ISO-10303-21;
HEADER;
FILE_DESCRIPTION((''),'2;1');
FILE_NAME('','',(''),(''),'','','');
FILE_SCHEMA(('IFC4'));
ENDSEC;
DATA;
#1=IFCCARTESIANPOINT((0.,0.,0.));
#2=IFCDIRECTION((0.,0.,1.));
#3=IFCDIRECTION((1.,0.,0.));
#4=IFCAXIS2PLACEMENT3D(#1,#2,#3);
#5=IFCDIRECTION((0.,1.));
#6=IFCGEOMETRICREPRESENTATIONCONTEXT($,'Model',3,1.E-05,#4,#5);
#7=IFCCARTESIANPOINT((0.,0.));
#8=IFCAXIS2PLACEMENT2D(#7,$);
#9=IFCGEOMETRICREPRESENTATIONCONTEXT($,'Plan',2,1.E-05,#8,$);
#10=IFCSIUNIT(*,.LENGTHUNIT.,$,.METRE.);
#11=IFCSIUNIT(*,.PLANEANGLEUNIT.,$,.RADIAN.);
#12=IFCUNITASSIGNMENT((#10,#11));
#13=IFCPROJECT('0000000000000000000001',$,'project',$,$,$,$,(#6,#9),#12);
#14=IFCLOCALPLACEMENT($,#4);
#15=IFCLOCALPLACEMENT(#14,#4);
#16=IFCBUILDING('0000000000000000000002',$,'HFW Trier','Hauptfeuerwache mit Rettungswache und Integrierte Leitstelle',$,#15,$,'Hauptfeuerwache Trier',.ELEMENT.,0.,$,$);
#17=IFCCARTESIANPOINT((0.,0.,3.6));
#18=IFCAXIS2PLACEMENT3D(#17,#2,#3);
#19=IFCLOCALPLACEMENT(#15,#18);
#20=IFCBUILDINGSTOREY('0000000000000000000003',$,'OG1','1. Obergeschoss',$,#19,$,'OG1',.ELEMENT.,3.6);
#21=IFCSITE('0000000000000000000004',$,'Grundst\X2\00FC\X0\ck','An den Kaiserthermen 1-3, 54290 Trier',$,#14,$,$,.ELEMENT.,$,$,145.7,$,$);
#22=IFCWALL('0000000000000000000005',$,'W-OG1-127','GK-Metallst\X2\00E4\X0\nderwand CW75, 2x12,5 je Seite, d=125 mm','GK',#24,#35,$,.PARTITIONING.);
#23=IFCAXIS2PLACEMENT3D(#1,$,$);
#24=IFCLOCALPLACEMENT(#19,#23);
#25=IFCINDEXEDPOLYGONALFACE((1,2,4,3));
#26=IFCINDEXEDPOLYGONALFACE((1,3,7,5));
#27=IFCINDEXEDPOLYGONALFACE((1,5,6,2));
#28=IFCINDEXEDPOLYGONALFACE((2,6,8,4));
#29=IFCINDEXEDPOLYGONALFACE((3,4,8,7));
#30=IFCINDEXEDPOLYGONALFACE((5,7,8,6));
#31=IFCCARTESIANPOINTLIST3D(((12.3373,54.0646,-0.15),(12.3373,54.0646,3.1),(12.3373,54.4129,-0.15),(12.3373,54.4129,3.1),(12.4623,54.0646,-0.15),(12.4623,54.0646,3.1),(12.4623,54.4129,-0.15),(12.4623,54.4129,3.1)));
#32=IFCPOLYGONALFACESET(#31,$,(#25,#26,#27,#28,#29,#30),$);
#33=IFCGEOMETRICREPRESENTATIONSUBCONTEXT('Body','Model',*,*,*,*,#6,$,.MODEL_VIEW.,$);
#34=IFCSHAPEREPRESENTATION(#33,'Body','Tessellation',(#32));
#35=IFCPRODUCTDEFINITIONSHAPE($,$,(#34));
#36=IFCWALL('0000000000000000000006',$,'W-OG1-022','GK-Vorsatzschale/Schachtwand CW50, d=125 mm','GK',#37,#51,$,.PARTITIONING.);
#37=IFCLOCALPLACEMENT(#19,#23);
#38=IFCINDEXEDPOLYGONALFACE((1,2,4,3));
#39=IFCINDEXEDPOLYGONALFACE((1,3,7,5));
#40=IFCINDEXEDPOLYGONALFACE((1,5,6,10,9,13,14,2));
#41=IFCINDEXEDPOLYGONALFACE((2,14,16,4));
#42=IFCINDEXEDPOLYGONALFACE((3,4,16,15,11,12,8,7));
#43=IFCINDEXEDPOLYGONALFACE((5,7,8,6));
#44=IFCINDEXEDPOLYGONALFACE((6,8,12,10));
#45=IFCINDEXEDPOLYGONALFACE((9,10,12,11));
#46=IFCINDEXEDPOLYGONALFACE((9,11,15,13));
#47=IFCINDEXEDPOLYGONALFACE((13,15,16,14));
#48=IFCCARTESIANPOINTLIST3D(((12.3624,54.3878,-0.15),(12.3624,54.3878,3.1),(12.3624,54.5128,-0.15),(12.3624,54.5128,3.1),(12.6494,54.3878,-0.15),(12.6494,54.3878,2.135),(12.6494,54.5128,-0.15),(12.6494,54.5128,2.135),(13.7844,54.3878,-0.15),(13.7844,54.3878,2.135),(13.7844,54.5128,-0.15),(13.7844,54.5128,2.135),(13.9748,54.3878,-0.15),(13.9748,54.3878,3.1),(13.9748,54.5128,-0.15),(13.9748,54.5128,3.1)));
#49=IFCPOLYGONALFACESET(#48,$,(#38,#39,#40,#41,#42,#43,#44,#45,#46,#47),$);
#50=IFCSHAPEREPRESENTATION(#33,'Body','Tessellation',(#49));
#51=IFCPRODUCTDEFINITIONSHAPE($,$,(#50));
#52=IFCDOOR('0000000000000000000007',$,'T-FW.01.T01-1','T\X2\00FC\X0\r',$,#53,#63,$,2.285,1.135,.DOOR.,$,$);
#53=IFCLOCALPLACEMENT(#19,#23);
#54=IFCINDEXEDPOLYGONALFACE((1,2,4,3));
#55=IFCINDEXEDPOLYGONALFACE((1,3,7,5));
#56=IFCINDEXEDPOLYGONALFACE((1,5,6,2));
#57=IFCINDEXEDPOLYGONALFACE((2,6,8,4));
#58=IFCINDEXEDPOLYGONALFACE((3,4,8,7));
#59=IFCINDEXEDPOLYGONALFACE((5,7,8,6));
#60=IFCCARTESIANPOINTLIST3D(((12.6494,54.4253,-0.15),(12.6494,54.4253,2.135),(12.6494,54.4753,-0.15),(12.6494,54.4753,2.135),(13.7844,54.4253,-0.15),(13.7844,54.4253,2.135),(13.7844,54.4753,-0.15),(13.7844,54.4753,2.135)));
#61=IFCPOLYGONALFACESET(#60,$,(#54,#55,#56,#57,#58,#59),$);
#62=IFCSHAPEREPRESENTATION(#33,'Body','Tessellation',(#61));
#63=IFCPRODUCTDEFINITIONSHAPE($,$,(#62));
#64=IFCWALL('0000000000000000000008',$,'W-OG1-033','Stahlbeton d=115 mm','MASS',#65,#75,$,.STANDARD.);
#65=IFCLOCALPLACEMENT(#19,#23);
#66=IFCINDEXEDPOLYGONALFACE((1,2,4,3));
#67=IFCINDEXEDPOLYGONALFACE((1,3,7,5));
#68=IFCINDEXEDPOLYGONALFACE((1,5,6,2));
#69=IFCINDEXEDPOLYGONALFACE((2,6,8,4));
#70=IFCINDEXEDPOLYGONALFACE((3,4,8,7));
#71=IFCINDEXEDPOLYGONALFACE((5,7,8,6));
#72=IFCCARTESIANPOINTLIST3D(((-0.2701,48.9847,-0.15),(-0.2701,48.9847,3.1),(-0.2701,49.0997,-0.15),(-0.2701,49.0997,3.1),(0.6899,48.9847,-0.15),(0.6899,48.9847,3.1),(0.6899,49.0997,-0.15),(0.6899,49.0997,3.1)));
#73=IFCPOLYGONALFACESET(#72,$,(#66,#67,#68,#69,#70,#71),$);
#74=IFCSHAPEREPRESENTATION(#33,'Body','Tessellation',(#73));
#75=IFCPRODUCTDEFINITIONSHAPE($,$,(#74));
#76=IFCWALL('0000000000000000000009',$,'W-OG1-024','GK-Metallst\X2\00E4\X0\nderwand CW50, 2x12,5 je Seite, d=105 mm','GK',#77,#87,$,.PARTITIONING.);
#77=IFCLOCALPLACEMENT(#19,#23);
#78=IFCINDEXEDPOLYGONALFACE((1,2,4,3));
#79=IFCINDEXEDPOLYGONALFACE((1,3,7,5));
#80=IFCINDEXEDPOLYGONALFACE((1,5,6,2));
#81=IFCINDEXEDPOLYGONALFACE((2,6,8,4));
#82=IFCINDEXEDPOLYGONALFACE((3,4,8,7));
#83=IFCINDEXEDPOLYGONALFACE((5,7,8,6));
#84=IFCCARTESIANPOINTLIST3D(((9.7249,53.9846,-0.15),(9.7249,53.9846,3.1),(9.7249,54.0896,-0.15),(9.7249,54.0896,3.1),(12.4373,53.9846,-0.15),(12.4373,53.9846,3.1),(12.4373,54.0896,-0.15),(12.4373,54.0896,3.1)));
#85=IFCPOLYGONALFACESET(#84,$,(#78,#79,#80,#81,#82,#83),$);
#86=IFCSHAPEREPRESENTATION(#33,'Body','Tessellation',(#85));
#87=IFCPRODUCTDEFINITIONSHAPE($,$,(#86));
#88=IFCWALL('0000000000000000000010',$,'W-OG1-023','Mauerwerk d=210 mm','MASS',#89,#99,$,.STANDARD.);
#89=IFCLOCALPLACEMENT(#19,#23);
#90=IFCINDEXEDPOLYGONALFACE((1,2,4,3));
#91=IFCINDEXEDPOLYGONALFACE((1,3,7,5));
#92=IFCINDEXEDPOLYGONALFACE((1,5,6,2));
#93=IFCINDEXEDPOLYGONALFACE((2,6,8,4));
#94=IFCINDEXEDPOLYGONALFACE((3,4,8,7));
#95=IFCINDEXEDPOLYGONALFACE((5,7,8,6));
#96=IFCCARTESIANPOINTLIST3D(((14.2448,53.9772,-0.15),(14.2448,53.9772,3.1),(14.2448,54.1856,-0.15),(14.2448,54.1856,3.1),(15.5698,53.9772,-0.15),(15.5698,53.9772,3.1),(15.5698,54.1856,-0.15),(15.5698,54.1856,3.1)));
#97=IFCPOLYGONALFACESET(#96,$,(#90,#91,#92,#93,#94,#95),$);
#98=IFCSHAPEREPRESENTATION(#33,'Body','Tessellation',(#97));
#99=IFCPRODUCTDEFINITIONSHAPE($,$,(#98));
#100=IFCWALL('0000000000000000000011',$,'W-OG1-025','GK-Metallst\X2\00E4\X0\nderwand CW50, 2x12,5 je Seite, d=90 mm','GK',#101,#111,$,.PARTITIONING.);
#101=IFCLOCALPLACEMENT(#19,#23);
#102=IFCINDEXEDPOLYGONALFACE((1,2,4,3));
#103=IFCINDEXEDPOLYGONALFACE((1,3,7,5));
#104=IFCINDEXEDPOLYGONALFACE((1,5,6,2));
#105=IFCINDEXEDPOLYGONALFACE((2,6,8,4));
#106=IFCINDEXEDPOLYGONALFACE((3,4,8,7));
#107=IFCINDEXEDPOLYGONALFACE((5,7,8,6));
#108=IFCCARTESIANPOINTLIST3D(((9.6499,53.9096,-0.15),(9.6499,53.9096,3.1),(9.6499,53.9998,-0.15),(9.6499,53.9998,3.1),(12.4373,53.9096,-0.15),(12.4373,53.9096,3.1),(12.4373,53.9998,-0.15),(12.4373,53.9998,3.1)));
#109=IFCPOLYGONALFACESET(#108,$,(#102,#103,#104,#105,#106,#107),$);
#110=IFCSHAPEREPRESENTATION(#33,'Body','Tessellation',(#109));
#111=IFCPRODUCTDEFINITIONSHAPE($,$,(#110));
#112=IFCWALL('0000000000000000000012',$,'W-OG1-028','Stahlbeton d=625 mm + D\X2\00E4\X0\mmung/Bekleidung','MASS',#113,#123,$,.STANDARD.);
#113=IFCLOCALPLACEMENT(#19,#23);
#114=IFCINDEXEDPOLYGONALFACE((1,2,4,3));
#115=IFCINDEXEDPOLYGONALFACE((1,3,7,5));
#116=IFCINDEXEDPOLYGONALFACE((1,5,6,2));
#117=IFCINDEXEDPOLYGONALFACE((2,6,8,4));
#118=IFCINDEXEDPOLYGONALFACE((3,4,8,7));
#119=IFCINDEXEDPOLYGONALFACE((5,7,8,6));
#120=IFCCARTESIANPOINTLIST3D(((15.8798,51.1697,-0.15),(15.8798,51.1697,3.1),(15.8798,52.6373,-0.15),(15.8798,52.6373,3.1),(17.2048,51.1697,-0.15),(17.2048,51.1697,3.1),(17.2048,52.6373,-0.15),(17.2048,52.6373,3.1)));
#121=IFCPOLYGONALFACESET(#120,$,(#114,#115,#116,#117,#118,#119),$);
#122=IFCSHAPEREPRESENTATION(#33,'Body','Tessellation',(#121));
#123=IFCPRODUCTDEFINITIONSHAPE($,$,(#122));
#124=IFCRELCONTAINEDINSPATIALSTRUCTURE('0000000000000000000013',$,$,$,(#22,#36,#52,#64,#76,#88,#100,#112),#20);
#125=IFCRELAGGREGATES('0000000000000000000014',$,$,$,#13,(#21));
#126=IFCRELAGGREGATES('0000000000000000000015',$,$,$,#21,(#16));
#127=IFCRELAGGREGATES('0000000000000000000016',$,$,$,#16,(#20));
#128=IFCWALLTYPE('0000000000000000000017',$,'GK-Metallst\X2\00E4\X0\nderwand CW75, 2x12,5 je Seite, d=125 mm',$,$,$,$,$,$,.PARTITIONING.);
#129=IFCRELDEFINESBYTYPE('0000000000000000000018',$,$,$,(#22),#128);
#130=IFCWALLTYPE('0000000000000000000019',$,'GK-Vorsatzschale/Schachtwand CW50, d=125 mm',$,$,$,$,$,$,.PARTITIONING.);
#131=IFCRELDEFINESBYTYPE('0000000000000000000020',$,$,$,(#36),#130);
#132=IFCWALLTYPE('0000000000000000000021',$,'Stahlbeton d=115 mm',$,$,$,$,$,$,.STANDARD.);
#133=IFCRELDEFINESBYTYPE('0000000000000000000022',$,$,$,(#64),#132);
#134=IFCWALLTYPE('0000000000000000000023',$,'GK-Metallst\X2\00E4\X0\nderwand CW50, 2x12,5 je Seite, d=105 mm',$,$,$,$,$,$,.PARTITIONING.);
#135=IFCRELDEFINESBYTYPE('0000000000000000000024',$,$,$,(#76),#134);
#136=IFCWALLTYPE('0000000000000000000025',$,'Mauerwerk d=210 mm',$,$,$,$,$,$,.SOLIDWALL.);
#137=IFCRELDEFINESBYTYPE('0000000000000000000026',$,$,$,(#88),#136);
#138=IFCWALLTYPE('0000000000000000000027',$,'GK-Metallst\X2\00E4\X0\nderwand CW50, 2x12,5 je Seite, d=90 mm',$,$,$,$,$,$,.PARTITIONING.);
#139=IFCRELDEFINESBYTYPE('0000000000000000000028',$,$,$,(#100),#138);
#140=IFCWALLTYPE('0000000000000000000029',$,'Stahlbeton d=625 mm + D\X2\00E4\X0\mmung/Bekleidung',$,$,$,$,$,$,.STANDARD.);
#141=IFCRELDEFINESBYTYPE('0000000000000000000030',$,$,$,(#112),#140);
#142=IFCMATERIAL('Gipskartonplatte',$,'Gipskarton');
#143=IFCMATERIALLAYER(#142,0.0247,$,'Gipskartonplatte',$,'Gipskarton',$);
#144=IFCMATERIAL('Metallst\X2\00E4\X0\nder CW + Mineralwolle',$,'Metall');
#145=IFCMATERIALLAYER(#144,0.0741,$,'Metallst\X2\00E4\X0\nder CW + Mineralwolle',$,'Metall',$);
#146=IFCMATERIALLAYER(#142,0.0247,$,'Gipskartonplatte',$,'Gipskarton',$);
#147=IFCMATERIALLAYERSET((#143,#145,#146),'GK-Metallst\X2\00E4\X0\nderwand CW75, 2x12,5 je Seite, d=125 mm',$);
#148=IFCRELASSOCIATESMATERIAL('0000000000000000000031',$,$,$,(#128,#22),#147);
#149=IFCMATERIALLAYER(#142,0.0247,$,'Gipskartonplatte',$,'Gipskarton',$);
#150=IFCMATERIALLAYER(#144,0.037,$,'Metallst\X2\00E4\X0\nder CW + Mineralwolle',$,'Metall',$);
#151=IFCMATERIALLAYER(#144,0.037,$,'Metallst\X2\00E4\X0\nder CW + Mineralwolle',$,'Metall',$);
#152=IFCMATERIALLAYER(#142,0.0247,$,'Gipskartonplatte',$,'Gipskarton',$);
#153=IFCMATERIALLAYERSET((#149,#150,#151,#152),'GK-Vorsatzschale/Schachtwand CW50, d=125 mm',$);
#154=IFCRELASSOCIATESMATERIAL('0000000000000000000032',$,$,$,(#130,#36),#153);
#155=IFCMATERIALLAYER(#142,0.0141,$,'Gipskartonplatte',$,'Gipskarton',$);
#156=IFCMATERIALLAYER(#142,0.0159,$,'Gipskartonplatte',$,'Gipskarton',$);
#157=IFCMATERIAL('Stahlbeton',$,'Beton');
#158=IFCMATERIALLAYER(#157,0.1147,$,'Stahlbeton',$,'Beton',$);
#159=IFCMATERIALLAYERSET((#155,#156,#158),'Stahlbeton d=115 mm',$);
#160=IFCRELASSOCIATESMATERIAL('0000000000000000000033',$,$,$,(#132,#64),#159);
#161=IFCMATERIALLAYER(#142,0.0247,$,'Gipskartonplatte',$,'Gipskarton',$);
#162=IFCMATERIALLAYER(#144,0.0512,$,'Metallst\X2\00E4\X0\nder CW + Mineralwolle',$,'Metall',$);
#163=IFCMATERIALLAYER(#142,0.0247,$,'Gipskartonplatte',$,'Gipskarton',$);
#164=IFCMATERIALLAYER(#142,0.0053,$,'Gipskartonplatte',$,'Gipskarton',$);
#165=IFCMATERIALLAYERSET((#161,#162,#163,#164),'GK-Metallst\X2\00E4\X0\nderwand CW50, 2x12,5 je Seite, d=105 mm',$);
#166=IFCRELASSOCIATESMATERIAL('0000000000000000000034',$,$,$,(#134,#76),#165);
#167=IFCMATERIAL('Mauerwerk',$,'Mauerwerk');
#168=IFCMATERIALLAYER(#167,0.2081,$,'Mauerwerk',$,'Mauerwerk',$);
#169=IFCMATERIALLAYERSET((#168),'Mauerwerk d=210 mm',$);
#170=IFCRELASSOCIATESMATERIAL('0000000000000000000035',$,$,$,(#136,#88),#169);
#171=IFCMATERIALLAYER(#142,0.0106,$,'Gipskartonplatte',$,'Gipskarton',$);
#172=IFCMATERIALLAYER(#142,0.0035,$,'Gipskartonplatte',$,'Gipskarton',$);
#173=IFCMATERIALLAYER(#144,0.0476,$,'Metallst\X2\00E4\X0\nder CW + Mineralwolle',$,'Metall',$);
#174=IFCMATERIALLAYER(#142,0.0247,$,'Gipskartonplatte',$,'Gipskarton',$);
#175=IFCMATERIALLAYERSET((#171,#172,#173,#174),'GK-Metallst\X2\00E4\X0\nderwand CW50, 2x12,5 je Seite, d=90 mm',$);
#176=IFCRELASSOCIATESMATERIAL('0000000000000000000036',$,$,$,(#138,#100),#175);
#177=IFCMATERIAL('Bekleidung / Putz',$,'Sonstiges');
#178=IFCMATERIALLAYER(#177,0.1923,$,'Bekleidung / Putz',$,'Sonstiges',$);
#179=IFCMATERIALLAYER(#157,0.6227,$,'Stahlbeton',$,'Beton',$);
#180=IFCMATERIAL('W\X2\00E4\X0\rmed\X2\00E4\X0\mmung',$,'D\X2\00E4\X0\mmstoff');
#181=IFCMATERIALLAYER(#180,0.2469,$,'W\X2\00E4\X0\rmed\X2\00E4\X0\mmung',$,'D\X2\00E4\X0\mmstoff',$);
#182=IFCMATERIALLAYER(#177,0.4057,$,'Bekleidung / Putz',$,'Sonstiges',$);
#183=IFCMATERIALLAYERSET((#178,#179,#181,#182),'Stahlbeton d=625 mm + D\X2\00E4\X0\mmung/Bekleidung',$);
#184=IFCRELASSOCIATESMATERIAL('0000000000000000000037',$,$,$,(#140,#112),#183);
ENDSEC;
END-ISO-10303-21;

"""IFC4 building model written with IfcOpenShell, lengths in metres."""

from ifc_helpers import new_model, si_unit, direction, frame, frame_2d, origin_with_axes, origin_2d, place, context, subcontext, project, spatial, rectangle, extrude, material, layer, layer_set, layer_usage, type_object, element, fill, save


model = new_model("IFC4")

# Units and contexts
model_context = context("Model", 3, precision=1e-05, world=origin_with_axes(), true_north=direction((0.0, 1.0)))
plan_context = context("Plan", 2, precision=1e-05, world=origin_2d())
body_context = subcontext(model_context, "Body", "Model", "MODEL_VIEW")
ifc_project = project(units=[si_unit("LENGTHUNIT", "METRE"), si_unit("PLANEANGLEUNIT", "RADIAN")], contexts=[model_context, plan_context])

# Site, building, storey
site_placement = place(None, origin_with_axes())
site = spatial("IfcSite", under=ifc_project, at=site_placement, Name="Grundstück", Description="An den Kaiserthermen 1-3, 54290 Trier", CompositionType="ELEMENT", RefElevation=145.7)
building_placement = place(site_placement, origin_with_axes())
building = spatial("IfcBuilding", under=site, at=building_placement, Name="HFW Trier", Description="Hauptfeuerwache mit Rettungswache und Integrierte Leitstelle", LongName="Hauptfeuerwache Trier", CompositionType="ELEMENT", ElevationOfRefHeight=0.0)
storey_placement = place(building_placement, frame((0.0, 0.0, 3.6), z_axis=(0.0, 0.0, 1.0), x_axis=(1.0, 0.0, 0.0)))
storey = spatial("IfcBuildingStorey", under=building, at=storey_placement, Name="OG1", Description="1. Obergeschoss", LongName="OG1", CompositionType="ELEMENT", Elevation=3.6)

# Shared definitions
ifc_material_1 = material(Name="Stahlbeton", Category="Beton")

# Wall
ifc_material_2 = material(Name="Gipskartonplatte", Category="Gipskarton")
ifc_layer_1 = layer(ifc_material_2, 0.0247, Name="Gipskartonplatte", Category="Gipskarton")
ifc_material_3 = material(Name="Metallständer CW + Mineralwolle", Category="Metall")
ifc_layer_2 = layer(ifc_material_3, 0.0741, Name="Metallständer CW + Mineralwolle", Category="Metall")
ifc_layer_3 = layer(ifc_material_2, 0.0247, Name="Gipskartonplatte", Category="Gipskarton")
ifc_layer_set_1 = layer_set([ifc_layer_1, ifc_layer_2, ifc_layer_3], Name="GK-Metallständerwand CW75, 2x12,5 je Seite, d=125 mm")
wall_type_1 = type_object("IfcWallType", Name="GK-Metallständerwand CW75, 2x12,5 je Seite, d=125 mm", PredefinedType="PARTITIONING", material=ifc_layer_set_1)
ifc_layer_usage_1 = layer_usage(ifc_layer_set_1, "AXIS2", "POSITIVE", -0.0625)
wall_1_placement = place(storey_placement, frame((12.3998, 54.4129, -0.15), z_axis=(0.0, 0.0, 1.0), x_axis=(0.0, -1.0, 0.0)))
element("IfcWall", 1, at=wall_1_placement, inside=storey, type_object=wall_type_1, material=ifc_layer_usage_1, Name="W-OG1-127", Description="GK-Metallständerwand CW75, 2x12,5 je Seite, d=125 mm", ObjectType="GK", PredefinedType="PARTITIONING", context=body_context, shape_type="SweptSolid", body=[
    extrude(rectangle(XDim=0.3483, YDim=0.125, at=frame_2d((0.1742, 0.0))), origin_with_axes(), (0.0, 0.0, 1.0), 3.25),
])

# Wall, opening, door
ifc_layer_4 = layer(ifc_material_2, 0.0247, Name="Gipskartonplatte", Category="Gipskarton")
ifc_layer_5 = layer(ifc_material_3, 0.037, Name="Metallständer CW + Mineralwolle", Category="Metall")
ifc_layer_6 = layer(ifc_material_3, 0.037, Name="Metallständer CW + Mineralwolle", Category="Metall")
ifc_layer_7 = layer(ifc_material_2, 0.0247, Name="Gipskartonplatte", Category="Gipskarton")
ifc_layer_set_2 = layer_set([ifc_layer_4, ifc_layer_5, ifc_layer_6, ifc_layer_7], Name="GK-Vorsatzschale/Schachtwand CW50, d=125 mm")
ifc_layer_usage_2 = layer_usage(ifc_layer_set_2, "AXIS2", "POSITIVE", -0.0624)
wall_type_2 = type_object("IfcWallType", Name="GK-Vorsatzschale/Schachtwand CW50, d=125 mm", PredefinedType="PARTITIONING", material=ifc_layer_set_2)
wall_2_placement = place(storey_placement, frame((12.3624, 54.4503, -0.15), z_axis=(0.0, 0.0, 1.0), x_axis=(1.0, 0.0, 0.0)))
wall_2 = element("IfcWall", 2, at=wall_2_placement, inside=storey, type_object=wall_type_2, material=ifc_layer_usage_2, Name="W-OG1-022", Description="GK-Vorsatzschale/Schachtwand CW50, d=125 mm", ObjectType="GK", PredefinedType="PARTITIONING", context=body_context, shape_type="SweptSolid", body=[
    extrude(rectangle(XDim=1.6124, YDim=0.1249, at=frame_2d((0.8062, 0.0))), origin_with_axes(), (0.0, 0.0, 1.0), 3.25),
])
opening_1_placement = place(wall_2_placement, frame((0.287, 0.0, 0.0), z_axis=(0.0, 0.0, 1.0), x_axis=(1.0, 0.0, 0.0)))
opening_1 = element("IfcOpeningElement", 3, at=opening_1_placement, cuts=wall_2, PredefinedType="OPENING", context=body_context, shape_type="SweptSolid", body=[
    extrude(rectangle(XDim=1.135, YDim=0.2249, at=frame_2d((0.5675, 0.0))), origin_with_axes(), (0.0, 0.0, 1.0), 2.285),
])
door_placement = place(wall_2_placement, frame((0.287, 0.0, 0.0), z_axis=(0.0, 0.0, 1.0), x_axis=(1.0, 0.0, 0.0)))
door = element("IfcDoor", 4, at=door_placement, inside=storey, Name="T-FW.01.T01-1", Description="Tür", OverallHeight=2.285, OverallWidth=1.135, PredefinedType="DOOR", context=body_context, shape_type="SweptSolid", body=[
    extrude(rectangle(XDim=1.135, YDim=0.05, at=frame_2d((0.5675, 0.0))), origin_with_axes(), (0.0, 0.0, 1.0), 2.285),
])
fill(opening_1, door)

# Walls
ifc_layer_8 = layer(ifc_material_2, 0.0141, Name="Gipskartonplatte", Category="Gipskarton")
ifc_layer_9 = layer(ifc_material_2, 0.0159, Name="Gipskartonplatte", Category="Gipskarton")
ifc_layer_10 = layer(ifc_material_1, 0.1147, Name="Stahlbeton", Category="Beton")
ifc_layer_set_3 = layer_set([ifc_layer_8, ifc_layer_9, ifc_layer_10], Name="Stahlbeton d=115 mm")
ifc_layer_usage_3 = layer_usage(ifc_layer_set_3, "AXIS2", "POSITIVE", -0.0575)
wall_type_3 = type_object("IfcWallType", Name="Stahlbeton d=115 mm", PredefinedType="STANDARD", material=ifc_layer_set_3)
wall_3_placement = place(storey_placement, frame((-0.2701, 49.0422, -0.15), z_axis=(0.0, 0.0, 1.0), x_axis=(1.0, 0.0, 0.0)))
element("IfcWall", 5, at=wall_3_placement, inside=storey, type_object=wall_type_3, material=ifc_layer_usage_3, Name="W-OG1-033", Description="Stahlbeton d=115 mm", ObjectType="MASS", PredefinedType="STANDARD", context=body_context, shape_type="SweptSolid", body=[
    extrude(rectangle(XDim=0.96, YDim=0.115, at=frame_2d((0.48, 0.0))), origin_with_axes(), (0.0, 0.0, 1.0), 3.25),
])
ifc_layer_11 = layer(ifc_material_2, 0.0247, Name="Gipskartonplatte", Category="Gipskarton")
ifc_layer_12 = layer(ifc_material_3, 0.0512, Name="Metallständer CW + Mineralwolle", Category="Metall")
ifc_layer_13 = layer(ifc_material_2, 0.0247, Name="Gipskartonplatte", Category="Gipskarton")
ifc_layer_14 = layer(ifc_material_2, 0.0053, Name="Gipskartonplatte", Category="Gipskarton")
ifc_layer_set_4 = layer_set([ifc_layer_11, ifc_layer_12, ifc_layer_13, ifc_layer_14], Name="GK-Metallständerwand CW50, 2x12,5 je Seite, d=105 mm")
ifc_layer_usage_4 = layer_usage(ifc_layer_set_4, "AXIS2", "POSITIVE", -0.0525)
wall_type_4 = type_object("IfcWallType", Name="GK-Metallständerwand CW50, 2x12,5 je Seite, d=105 mm", PredefinedType="PARTITIONING", material=ifc_layer_set_4)
wall_4_placement = place(storey_placement, frame((9.7249, 54.0371, -0.15), z_axis=(0.0, 0.0, 1.0), x_axis=(1.0, 0.0, 0.0)))
element("IfcWall", 6, at=wall_4_placement, inside=storey, type_object=wall_type_4, material=ifc_layer_usage_4, Name="W-OG1-024", Description="GK-Metallständerwand CW50, 2x12,5 je Seite, d=105 mm", ObjectType="GK", PredefinedType="PARTITIONING", context=body_context, shape_type="SweptSolid", body=[
    extrude(rectangle(XDim=2.7124, YDim=0.1051, at=frame_2d((1.3562, 0.0))), origin_with_axes(), (0.0, 0.0, 1.0), 3.25),
])
ifc_material_4 = material(Name="Mauerwerk", Category="Mauerwerk")
ifc_layer_15 = layer(ifc_material_4, 0.2081, Name="Mauerwerk", Category="Mauerwerk")
ifc_layer_set_5 = layer_set([ifc_layer_15], Name="Mauerwerk d=210 mm")
ifc_layer_usage_5 = layer_usage(ifc_layer_set_5, "AXIS2", "POSITIVE", -0.1042)
wall_type_5 = type_object("IfcWallType", Name="Mauerwerk d=210 mm", PredefinedType="SOLIDWALL", material=ifc_layer_set_5)
wall_5_placement = place(storey_placement, frame((14.2448, 54.0814, -0.15), z_axis=(0.0, 0.0, 1.0), x_axis=(1.0, 0.0, 0.0)))
element("IfcWall", 7, at=wall_5_placement, inside=storey, type_object=wall_type_5, material=ifc_layer_usage_5, Name="W-OG1-023", Description="Mauerwerk d=210 mm", ObjectType="MASS", PredefinedType="STANDARD", context=body_context, shape_type="SweptSolid", body=[
    extrude(rectangle(XDim=1.325, YDim=0.2085, at=frame_2d((0.6625, 0.0))), origin_with_axes(), (0.0, 0.0, 1.0), 3.25),
])
ifc_layer_16 = layer(ifc_material_2, 0.0106, Name="Gipskartonplatte", Category="Gipskarton")
ifc_layer_17 = layer(ifc_material_2, 0.0035, Name="Gipskartonplatte", Category="Gipskarton")
ifc_layer_18 = layer(ifc_material_3, 0.0476, Name="Metallständer CW + Mineralwolle", Category="Metall")
ifc_layer_19 = layer(ifc_material_2, 0.0247, Name="Gipskartonplatte", Category="Gipskarton")
ifc_layer_set_6 = layer_set([ifc_layer_16, ifc_layer_17, ifc_layer_18, ifc_layer_19], Name="GK-Metallständerwand CW50, 2x12,5 je Seite, d=90 mm")
ifc_layer_usage_6 = layer_usage(ifc_layer_set_6, "AXIS2", "POSITIVE", -0.045)
wall_type_6 = type_object("IfcWallType", Name="GK-Metallständerwand CW50, 2x12,5 je Seite, d=90 mm", PredefinedType="PARTITIONING", material=ifc_layer_set_6)
wall_6_placement = place(storey_placement, frame((9.6499, 53.9547, -0.15), z_axis=(0.0, 0.0, 1.0), x_axis=(1.0, 0.0, 0.0)))
element("IfcWall", 8, at=wall_6_placement, inside=storey, type_object=wall_type_6, material=ifc_layer_usage_6, Name="W-OG1-025", Description="GK-Metallständerwand CW50, 2x12,5 je Seite, d=90 mm", ObjectType="GK", PredefinedType="PARTITIONING", context=body_context, shape_type="SweptSolid", body=[
    extrude(rectangle(XDim=2.7874, YDim=0.0901, at=frame_2d((1.3937, 0.0))), origin_with_axes(), (0.0, 0.0, 1.0), 3.25),
])
ifc_material_5 = material(Name="Bekleidung / Putz", Category="Sonstiges")
ifc_layer_20 = layer(ifc_material_5, 0.1923, Name="Bekleidung / Putz", Category="Sonstiges")
ifc_layer_21 = layer(ifc_material_1, 0.6227, Name="Stahlbeton", Category="Beton")
ifc_material_6 = material(Name="Wärmedämmung", Category="Dämmstoff")
ifc_layer_22 = layer(ifc_material_6, 0.2469, Name="Wärmedämmung", Category="Dämmstoff")
ifc_layer_23 = layer(ifc_material_5, 0.4057, Name="Bekleidung / Putz", Category="Sonstiges")
ifc_layer_set_7 = layer_set([ifc_layer_20, ifc_layer_21, ifc_layer_22, ifc_layer_23], Name="Stahlbeton d=625 mm + Dämmung/Bekleidung")
ifc_layer_usage_7 = layer_usage(ifc_layer_set_7, "AXIS2", "POSITIVE", -0.7338)
wall_type_7 = type_object("IfcWallType", Name="Stahlbeton d=625 mm + Dämmung/Bekleidung", PredefinedType="STANDARD", material=ifc_layer_set_7)
wall_7_placement = place(storey_placement, frame((15.8798, 51.9035, -0.15), z_axis=(0.0, 0.0, 1.0), x_axis=(1.0, 0.0, 0.0)))
element("IfcWall", 9, at=wall_7_placement, inside=storey, type_object=wall_type_7, material=ifc_layer_usage_7, Name="W-OG1-028", Description="Stahlbeton d=625 mm + Dämmung/Bekleidung", ObjectType="MASS", PredefinedType="STANDARD", context=body_context, shape_type="SweptSolid", body=[
    extrude(rectangle(XDim=1.325, YDim=1.4676, at=frame_2d((0.6625, 0.0))), origin_with_axes(), (0.0, 0.0, 1.0), 3.25),
])

save(model, "model.ifc")
